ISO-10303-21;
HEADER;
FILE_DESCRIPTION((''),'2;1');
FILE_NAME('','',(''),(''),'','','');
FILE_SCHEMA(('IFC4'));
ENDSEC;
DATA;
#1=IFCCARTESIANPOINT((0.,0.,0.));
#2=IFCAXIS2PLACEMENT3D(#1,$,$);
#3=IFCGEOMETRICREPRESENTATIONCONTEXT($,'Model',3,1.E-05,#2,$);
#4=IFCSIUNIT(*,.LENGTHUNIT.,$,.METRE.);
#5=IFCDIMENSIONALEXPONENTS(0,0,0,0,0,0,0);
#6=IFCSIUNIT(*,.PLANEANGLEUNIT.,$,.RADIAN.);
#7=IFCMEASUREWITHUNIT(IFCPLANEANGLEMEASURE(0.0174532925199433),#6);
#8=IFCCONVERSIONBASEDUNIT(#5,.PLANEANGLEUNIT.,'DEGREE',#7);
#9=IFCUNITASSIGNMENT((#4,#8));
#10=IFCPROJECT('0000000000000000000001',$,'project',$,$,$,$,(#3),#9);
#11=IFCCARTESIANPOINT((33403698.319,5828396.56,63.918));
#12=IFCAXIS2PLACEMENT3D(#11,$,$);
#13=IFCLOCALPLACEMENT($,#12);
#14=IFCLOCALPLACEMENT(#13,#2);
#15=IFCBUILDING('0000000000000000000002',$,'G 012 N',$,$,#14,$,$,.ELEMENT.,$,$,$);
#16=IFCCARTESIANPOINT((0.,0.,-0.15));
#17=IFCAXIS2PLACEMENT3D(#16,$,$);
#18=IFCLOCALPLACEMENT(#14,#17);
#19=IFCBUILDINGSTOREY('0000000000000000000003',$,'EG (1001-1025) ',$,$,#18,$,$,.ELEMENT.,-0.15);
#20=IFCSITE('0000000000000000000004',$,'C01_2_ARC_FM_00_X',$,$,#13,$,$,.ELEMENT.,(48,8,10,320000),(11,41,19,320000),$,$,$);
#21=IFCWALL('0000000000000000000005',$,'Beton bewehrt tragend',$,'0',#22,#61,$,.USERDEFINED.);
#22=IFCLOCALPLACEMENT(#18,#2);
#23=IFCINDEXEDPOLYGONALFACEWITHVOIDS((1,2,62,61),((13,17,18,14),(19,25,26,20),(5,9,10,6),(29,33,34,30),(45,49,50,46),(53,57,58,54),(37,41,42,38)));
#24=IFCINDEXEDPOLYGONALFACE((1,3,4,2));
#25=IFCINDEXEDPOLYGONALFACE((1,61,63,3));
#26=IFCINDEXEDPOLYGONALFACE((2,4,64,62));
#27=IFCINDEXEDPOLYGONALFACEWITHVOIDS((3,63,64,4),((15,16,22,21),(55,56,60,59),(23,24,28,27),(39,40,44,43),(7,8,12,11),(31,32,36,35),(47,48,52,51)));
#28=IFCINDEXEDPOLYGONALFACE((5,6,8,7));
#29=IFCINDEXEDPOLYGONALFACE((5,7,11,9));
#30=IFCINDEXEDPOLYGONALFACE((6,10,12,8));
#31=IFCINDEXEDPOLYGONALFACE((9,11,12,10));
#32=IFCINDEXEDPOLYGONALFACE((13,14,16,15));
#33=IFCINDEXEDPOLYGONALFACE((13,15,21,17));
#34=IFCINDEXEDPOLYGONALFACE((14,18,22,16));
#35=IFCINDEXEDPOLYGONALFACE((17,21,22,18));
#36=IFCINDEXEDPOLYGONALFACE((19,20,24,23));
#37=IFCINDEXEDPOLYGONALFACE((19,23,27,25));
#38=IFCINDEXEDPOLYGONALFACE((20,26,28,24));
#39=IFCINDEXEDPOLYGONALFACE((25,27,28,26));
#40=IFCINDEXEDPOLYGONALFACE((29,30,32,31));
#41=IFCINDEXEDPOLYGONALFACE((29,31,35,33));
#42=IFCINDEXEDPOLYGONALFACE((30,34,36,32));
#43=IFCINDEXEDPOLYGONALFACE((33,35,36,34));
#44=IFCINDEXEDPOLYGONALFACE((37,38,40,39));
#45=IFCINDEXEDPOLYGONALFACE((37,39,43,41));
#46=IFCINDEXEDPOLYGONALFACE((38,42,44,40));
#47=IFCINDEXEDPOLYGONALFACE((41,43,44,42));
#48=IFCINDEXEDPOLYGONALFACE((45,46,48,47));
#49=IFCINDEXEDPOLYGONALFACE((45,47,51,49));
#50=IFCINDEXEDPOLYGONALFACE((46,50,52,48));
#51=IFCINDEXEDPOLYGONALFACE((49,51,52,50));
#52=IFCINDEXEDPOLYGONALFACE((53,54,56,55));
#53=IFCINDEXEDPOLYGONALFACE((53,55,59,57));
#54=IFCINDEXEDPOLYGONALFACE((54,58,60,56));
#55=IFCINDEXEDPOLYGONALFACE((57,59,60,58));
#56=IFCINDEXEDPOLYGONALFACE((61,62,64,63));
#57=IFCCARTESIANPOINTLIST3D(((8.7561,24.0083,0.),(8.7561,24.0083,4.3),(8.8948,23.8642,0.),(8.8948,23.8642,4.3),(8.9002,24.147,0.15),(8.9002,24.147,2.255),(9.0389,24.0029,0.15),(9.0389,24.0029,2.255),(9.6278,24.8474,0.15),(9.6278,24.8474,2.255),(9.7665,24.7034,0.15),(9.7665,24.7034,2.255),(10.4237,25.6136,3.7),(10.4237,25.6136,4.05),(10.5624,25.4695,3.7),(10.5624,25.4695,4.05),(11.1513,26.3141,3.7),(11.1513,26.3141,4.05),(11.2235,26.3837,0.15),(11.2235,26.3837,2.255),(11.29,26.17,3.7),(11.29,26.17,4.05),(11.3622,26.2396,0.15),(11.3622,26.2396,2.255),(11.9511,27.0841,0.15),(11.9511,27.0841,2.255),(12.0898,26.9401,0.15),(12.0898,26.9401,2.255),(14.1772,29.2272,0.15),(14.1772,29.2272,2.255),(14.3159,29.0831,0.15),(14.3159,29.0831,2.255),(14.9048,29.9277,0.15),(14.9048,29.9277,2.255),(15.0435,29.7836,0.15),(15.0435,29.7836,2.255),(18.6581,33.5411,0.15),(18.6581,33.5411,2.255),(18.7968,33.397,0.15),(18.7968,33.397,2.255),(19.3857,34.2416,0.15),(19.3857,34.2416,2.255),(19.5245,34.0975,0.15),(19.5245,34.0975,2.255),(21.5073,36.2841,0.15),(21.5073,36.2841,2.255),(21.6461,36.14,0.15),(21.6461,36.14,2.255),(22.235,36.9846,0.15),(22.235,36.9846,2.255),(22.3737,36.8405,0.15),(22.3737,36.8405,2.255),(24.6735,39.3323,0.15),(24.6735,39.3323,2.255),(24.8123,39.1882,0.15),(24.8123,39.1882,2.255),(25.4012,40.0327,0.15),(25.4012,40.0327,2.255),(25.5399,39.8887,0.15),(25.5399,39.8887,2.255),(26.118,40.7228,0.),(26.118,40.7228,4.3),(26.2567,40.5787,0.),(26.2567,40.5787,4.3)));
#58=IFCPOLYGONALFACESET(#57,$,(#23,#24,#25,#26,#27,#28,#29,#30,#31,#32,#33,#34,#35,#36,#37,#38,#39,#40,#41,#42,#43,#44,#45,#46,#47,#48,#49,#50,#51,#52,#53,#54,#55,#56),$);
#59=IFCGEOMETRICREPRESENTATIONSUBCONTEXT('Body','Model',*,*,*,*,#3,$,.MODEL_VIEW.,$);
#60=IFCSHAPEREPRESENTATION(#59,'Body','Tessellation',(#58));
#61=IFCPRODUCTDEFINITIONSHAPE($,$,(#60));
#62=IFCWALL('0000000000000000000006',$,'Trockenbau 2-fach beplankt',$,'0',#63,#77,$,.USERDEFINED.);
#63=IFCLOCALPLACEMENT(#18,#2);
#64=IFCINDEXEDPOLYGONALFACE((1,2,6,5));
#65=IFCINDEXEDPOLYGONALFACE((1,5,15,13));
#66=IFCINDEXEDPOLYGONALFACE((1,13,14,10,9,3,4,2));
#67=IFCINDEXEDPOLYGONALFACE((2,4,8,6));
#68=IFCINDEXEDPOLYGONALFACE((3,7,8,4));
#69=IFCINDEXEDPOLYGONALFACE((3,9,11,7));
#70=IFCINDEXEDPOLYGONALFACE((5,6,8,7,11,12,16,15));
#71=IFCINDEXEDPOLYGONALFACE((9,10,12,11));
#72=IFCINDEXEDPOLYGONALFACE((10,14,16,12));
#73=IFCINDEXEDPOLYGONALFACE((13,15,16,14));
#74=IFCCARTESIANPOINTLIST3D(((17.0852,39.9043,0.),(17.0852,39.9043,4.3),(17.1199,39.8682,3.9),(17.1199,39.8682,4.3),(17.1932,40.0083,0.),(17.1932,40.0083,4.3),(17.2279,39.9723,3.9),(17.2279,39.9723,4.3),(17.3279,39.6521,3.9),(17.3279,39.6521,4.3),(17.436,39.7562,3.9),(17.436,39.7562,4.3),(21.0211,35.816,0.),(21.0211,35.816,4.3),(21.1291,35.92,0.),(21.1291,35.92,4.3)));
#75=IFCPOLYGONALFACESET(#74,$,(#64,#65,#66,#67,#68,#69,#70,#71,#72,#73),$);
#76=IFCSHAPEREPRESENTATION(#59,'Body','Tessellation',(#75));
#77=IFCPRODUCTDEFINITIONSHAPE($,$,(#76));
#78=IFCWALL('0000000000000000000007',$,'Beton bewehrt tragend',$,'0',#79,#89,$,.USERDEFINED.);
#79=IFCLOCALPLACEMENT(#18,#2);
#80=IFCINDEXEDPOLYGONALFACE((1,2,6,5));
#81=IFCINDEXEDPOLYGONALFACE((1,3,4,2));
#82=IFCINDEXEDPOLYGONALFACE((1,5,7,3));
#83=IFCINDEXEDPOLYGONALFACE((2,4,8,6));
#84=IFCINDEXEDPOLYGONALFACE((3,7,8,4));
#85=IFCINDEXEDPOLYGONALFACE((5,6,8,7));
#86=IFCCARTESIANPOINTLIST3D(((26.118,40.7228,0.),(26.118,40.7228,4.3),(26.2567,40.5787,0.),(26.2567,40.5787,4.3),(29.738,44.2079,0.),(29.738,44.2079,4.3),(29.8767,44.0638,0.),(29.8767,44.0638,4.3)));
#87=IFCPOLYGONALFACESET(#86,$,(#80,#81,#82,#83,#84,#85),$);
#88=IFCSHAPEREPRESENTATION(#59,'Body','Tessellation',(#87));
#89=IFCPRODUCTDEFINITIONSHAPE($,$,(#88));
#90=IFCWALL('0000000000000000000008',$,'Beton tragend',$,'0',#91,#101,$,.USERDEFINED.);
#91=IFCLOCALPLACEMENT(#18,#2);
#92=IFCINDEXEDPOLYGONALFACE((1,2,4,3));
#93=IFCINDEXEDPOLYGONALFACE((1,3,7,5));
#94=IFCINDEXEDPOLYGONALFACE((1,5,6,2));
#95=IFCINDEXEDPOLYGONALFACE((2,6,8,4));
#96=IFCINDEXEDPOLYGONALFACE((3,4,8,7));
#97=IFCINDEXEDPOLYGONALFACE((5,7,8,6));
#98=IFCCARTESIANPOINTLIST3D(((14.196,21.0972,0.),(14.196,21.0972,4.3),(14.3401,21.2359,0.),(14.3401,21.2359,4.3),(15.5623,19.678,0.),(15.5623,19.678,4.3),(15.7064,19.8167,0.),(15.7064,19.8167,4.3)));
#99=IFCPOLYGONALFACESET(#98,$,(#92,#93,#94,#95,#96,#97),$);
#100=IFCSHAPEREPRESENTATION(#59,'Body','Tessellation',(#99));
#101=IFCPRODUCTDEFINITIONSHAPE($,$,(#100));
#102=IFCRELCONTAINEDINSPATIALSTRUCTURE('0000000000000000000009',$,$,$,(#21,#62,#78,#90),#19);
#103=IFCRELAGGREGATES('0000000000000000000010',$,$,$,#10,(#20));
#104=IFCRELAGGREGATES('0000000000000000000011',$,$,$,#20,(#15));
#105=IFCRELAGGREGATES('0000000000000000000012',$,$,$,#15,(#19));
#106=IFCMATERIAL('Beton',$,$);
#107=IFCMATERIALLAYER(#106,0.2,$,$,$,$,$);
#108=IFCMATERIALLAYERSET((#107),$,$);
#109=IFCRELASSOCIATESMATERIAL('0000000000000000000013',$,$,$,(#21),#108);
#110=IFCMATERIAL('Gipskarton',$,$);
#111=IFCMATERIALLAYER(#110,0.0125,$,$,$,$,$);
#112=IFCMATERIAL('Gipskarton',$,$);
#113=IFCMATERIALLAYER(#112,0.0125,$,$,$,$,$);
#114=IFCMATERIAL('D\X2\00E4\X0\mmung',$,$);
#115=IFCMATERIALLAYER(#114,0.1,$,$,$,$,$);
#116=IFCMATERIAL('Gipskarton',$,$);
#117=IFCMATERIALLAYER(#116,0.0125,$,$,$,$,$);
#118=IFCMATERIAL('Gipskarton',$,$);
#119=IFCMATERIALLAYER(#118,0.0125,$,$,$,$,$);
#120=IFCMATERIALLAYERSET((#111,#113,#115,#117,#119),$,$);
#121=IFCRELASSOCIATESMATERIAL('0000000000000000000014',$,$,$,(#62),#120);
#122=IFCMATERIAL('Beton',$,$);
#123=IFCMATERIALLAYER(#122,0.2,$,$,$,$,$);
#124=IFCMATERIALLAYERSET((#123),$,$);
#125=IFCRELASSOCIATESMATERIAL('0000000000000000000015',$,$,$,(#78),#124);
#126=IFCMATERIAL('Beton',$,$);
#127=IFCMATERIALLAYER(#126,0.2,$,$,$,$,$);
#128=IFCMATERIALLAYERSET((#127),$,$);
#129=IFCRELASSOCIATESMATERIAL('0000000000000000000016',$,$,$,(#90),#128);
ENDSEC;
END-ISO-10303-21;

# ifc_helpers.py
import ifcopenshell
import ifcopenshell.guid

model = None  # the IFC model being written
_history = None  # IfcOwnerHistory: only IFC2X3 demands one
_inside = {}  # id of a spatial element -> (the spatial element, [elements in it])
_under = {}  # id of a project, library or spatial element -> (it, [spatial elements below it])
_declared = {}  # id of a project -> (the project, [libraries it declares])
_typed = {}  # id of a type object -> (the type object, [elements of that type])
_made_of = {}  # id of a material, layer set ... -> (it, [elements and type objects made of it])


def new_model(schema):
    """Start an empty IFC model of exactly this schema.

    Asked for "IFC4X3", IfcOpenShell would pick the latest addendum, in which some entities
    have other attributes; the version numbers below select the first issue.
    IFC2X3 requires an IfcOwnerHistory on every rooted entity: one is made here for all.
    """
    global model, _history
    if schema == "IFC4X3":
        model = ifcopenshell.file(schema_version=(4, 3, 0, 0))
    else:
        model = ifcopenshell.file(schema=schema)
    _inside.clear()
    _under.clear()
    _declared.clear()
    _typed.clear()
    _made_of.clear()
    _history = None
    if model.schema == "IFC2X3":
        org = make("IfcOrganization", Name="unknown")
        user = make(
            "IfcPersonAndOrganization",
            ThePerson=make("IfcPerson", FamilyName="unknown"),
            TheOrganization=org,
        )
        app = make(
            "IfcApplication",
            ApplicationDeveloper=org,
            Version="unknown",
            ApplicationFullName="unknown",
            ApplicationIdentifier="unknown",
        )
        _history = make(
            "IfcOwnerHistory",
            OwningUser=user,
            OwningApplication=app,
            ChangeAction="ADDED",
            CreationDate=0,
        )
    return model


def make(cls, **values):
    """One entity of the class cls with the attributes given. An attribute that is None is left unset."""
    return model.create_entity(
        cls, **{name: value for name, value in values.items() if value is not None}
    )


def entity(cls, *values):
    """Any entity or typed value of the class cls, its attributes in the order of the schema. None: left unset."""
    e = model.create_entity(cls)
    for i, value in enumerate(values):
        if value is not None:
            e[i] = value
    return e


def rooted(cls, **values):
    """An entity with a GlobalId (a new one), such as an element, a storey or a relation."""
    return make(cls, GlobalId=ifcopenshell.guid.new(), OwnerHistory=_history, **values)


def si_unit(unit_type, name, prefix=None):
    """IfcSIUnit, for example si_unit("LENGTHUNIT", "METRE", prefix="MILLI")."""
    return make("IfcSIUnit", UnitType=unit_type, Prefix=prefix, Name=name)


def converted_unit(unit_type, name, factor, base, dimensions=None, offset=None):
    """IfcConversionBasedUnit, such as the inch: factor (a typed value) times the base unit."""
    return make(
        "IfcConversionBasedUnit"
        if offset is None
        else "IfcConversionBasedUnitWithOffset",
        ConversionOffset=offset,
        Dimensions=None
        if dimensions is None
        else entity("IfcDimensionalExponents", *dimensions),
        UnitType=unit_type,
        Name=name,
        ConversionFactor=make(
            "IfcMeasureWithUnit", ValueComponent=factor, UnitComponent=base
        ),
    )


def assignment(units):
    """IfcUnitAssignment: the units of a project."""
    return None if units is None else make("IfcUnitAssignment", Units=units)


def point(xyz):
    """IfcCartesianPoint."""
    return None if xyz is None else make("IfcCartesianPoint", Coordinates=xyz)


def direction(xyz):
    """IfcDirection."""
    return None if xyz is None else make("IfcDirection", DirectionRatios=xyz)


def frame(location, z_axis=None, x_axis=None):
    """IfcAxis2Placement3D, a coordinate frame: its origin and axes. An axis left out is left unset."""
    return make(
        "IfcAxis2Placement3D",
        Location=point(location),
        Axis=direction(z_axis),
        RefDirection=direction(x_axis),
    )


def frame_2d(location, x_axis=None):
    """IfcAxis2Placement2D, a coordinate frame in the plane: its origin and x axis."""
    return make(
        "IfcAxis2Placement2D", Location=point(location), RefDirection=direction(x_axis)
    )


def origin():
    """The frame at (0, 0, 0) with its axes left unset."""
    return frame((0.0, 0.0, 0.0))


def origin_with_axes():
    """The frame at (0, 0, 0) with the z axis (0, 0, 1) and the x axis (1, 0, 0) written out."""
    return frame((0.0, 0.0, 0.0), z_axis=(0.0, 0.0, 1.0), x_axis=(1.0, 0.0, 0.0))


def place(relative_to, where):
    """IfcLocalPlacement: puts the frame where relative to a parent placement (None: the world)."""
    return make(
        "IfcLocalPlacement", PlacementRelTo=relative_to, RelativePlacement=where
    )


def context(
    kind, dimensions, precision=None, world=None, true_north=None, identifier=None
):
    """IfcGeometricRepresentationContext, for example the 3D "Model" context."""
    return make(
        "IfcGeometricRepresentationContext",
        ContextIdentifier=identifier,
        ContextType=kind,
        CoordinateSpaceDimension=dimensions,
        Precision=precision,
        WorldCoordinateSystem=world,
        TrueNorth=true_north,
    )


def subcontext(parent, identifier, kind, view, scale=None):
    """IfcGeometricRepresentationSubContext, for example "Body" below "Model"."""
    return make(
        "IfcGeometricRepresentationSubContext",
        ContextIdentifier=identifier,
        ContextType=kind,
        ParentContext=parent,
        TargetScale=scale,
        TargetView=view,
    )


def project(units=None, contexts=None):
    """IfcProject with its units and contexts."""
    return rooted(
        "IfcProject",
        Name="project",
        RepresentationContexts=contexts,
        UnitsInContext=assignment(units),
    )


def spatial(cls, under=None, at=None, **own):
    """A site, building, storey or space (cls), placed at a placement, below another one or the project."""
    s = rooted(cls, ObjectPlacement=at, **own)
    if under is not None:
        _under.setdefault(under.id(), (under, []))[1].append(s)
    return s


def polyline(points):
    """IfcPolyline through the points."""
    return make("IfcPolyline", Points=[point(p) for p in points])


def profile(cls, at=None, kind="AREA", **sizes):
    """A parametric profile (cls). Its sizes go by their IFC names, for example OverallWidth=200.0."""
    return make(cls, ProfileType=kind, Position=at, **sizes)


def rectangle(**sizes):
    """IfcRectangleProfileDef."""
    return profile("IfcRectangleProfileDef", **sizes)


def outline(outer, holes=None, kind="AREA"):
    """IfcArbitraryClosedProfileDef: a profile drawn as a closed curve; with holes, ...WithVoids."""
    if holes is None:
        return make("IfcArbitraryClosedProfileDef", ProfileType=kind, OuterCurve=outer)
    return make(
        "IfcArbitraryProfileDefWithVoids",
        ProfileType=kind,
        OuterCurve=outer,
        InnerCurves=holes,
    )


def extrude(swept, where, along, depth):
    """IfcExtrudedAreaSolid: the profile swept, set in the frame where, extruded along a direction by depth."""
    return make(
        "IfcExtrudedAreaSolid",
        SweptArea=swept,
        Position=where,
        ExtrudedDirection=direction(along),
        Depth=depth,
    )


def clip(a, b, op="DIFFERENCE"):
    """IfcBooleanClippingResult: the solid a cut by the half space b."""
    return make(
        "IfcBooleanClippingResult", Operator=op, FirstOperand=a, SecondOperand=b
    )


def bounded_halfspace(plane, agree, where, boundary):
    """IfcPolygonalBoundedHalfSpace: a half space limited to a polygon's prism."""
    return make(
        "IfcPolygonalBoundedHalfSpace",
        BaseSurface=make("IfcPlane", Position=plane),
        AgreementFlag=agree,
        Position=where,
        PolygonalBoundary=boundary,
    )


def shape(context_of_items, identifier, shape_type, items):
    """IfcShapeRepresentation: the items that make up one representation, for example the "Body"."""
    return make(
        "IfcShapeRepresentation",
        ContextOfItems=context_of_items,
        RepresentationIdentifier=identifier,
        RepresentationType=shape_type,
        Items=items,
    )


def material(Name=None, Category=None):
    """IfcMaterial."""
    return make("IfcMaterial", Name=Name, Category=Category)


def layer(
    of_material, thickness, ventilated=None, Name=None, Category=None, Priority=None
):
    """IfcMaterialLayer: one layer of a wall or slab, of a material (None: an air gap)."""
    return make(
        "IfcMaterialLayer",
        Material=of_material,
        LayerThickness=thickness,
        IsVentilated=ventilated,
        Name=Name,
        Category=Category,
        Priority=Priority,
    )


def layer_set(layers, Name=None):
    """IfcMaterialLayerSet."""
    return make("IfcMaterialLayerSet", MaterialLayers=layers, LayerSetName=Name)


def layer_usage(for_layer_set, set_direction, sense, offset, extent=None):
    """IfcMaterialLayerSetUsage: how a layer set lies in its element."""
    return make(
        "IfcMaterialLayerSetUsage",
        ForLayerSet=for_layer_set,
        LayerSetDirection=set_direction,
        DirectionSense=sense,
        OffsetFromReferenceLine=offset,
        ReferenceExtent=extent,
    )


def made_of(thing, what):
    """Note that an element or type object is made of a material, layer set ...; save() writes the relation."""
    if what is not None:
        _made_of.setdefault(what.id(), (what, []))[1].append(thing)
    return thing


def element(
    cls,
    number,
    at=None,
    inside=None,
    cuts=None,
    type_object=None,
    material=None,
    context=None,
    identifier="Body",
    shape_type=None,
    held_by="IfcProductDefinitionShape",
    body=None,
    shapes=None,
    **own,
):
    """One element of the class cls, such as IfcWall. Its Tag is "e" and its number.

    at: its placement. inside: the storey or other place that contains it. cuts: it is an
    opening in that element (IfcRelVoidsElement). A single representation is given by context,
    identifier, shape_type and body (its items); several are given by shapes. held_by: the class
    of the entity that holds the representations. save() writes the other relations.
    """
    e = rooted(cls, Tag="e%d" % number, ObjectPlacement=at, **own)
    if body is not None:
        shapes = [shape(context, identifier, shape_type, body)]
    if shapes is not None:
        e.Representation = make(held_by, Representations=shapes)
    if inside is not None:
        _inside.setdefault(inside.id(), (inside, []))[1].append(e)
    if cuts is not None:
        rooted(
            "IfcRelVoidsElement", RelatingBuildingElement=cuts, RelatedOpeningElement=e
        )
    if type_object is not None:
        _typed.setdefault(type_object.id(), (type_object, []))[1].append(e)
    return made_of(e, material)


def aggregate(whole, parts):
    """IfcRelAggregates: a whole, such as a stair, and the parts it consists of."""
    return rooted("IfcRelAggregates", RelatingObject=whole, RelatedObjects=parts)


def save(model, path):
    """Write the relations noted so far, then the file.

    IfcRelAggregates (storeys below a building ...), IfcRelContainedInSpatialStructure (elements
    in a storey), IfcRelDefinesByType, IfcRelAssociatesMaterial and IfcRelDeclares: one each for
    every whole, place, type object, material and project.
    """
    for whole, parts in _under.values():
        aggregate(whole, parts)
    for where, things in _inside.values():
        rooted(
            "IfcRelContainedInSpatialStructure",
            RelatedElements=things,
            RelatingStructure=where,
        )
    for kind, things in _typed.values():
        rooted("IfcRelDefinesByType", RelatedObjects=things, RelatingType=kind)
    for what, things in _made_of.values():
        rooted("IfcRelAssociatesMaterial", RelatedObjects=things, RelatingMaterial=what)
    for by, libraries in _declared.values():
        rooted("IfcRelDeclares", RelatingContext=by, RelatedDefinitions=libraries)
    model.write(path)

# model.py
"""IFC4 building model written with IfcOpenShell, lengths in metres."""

from ifc_helpers import new_model, entity, si_unit, converted_unit, frame, frame_2d, origin, origin_with_axes, place, context, subcontext, project, spatial, polyline, rectangle, outline, extrude, clip, bounded_halfspace, material, layer, layer_set, layer_usage, element, save


model = new_model("IFC4")

# Units and contexts
model_context = context("Model", 3, precision=1e-05, world=origin())
body_context = subcontext(model_context, "Body", "Model", "MODEL_VIEW")
ifc_project = project(units=[si_unit("LENGTHUNIT", "METRE"), converted_unit("PLANEANGLEUNIT", "DEGREE", entity("IfcPlaneAngleMeasure", 0.0174532925199433), si_unit("PLANEANGLEUNIT", "RADIAN"), dimensions=[0, 0, 0, 0, 0, 0, 0])], contexts=[model_context])

# Site, building, storey
site_placement = place(None, frame((33403698.319, 5828396.56, 63.918)))
site = spatial("IfcSite", under=ifc_project, at=site_placement, Name="C01_2_ARC_FM_00_X", CompositionType="ELEMENT", RefLatitude=(48, 8, 10, 320000), RefLongitude=(11, 41, 19, 320000))
building_placement = place(site_placement, origin())
building = spatial("IfcBuilding", under=site, at=building_placement, Name="G 012 N", CompositionType="ELEMENT")
storey_placement = place(building_placement, frame((0.0, 0.0, -0.15)))
storey = spatial("IfcBuildingStorey", under=building, at=storey_placement, Name="EG (1001-1025) ", CompositionType="ELEMENT", Elevation=-0.15)

# Wall, openings
ifc_material_1 = material(Name="Beton")
ifc_layer_1 = layer(ifc_material_1, 0.2)
ifc_layer_set_1 = layer_set([ifc_layer_1])
ifc_layer_usage_1 = layer_usage(ifc_layer_set_1, "AXIS2", "POSITIVE", 0.0)
wall_1_placement = place(storey_placement, frame((26.118, 40.7228, 0.0), z_axis=(0.0, 0.0, 1.0), x_axis=(-0.720408, -0.693551, 0.0)))
wall_1 = element("IfcWall", 1, at=wall_1_placement, inside=storey, material=ifc_layer_usage_1, Name="Beton bewehrt tragend", ObjectType="0", PredefinedType="USERDEFINED", context=body_context, shape_type="SweptSolid", body=[
    extrude(rectangle(XDim=24.1, YDim=0.2, at=frame_2d((12.05, 0.1), x_axis=(1.0, 0.0))), origin_with_axes(), (0.0, 0.0, 1.0), 4.3),
])
opening_1_placement = place(wall_1_placement, frame((15.565, 0.0, 0.15), z_axis=(0.0, 1.0, 0.0), x_axis=(0.0, 0.0, 1.0)))
element("IfcOpeningElement", 2, at=opening_1_placement, cuts=wall_1, ObjectType="Opening", context=body_context, shape_type="SweptSolid", body=[
    extrude(outline(polyline([(0.0, 1.01), (2.105, 1.01), (2.105, 0.0), (0.0, 0.0), (0.0, 1.01)])), origin_with_axes(), (0.0, 0.0, 1.0), 0.2),
])
opening_2_placement = place(wall_1_placement, frame((0.995, 0.0, 0.15), z_axis=(0.0, 1.0, 0.0), x_axis=(0.0, 0.0, 1.0)))
element("IfcOpeningElement", 3, at=opening_2_placement, cuts=wall_1, ObjectType="Opening", context=body_context, shape_type="SweptSolid", body=[
    extrude(outline(polyline([(0.0, 1.01), (2.105, 1.01), (2.105, 0.0), (0.0, 0.0), (0.0, 1.01)])), origin_with_axes(), (0.0, 0.0, 1.0), 0.2),
])
opening_3_placement = place(wall_1_placement, frame((5.39, 0.0, 0.15), z_axis=(0.0, 1.0, 0.0), x_axis=(0.0, 0.0, 1.0)))
element("IfcOpeningElement", 4, at=opening_3_placement, cuts=wall_1, ObjectType="Opening", context=body_context, shape_type="SweptSolid", body=[
    extrude(outline(polyline([(0.0, 1.01), (2.105, 1.01), (2.105, 0.0), (0.0, 0.0), (0.0, 1.01)])), origin_with_axes(), (0.0, 0.0, 1.0), 0.2),
])
opening_4_placement = place(wall_1_placement, frame((9.345, 0.0, 0.15), z_axis=(0.0, 1.0, 0.0), x_axis=(0.0, 0.0, 1.0)))
element("IfcOpeningElement", 5, at=opening_4_placement, cuts=wall_1, ObjectType="Opening", context=body_context, shape_type="SweptSolid", body=[
    extrude(outline(polyline([(0.0, 1.01), (2.105, 1.01), (2.105, 0.0), (0.0, 0.0), (0.0, 1.01)])), origin_with_axes(), (0.0, 0.0, 1.0), 0.2),
])
opening_5_placement = place(wall_1_placement, frame((23.9, 0.2, 0.15), z_axis=(0.0, -1.0, 0.0), x_axis=(0.0, 0.0, 1.0)))
element("IfcOpeningElement", 6, at=opening_5_placement, cuts=wall_1, ObjectType="Opening", context=body_context, shape_type="SweptSolid", body=[
    extrude(outline(polyline([(0.0, 1.01), (2.105, 1.01), (2.105, 0.0), (0.0, 0.0), (0.0, 1.01)])), origin_with_axes(), (0.0, 0.0, 1.0), 0.2),
])
opening_6_placement = place(wall_1_placement, frame((19.665, 0.0, 0.15), z_axis=(0.0, 1.0, 0.0), x_axis=(0.0, 0.0, 1.0)))
element("IfcOpeningElement", 7, at=opening_6_placement, cuts=wall_1, ObjectType="Opening", context=body_context, shape_type="SweptSolid", body=[
    extrude(outline(polyline([(0.0, 1.01), (2.105, 1.01), (2.105, 0.0), (0.0, 0.0), (0.0, 1.01)])), origin_with_axes(), (0.0, 0.0, 1.0), 0.2),
])
opening_7_placement = place(wall_1_placement, frame((21.7853, 0.2, 3.7), z_axis=(0.0, -1.0, 0.0), x_axis=(0.0, 0.0, 1.0)))
element("IfcOpeningElement", 8, at=opening_7_placement, cuts=wall_1, ObjectType="Opening", context=body_context, shape_type="SweptSolid", body=[
    extrude(outline(polyline([(0.0, 1.01), (0.35, 1.01), (0.35, 0.0), (0.0, 0.0), (0.0, 1.01)])), origin_with_axes(), (0.0, 0.0, 1.0), 0.2),
])

# Walls
ifc_material_2 = material(Name="Gipskarton")
ifc_layer_2 = layer(ifc_material_2, 0.0125)
ifc_material_3 = material(Name="Gipskarton")
ifc_layer_3 = layer(ifc_material_3, 0.0125)
ifc_material_4 = material(Name="Dämmung")
ifc_layer_4 = layer(ifc_material_4, 0.1)
ifc_material_5 = material(Name="Gipskarton")
ifc_layer_5 = layer(ifc_material_5, 0.0125)
ifc_material_6 = material(Name="Gipskarton")
ifc_layer_6 = layer(ifc_material_6, 0.0125)
ifc_layer_set_2 = layer_set([ifc_layer_2, ifc_layer_3, ifc_layer_4, ifc_layer_5, ifc_layer_6])
ifc_layer_usage_2 = layer_usage(ifc_layer_set_2, "AXIS2", "POSITIVE", 0.0)
wall_2_placement = place(storey_placement, frame((17.0852, 39.9043, 0.0), z_axis=(0.0, 0.0, 1.0), x_axis=(0.693551, -0.720408, 0.0)))
element("IfcWall", 9, at=wall_2_placement, inside=storey, material=ifc_layer_usage_2, Name="Trockenbau 2-fach beplankt", ObjectType="0", PredefinedType="USERDEFINED", context=body_context, shape_type="Clipping", body=[
    clip(extrude(rectangle(XDim=5.675, YDim=0.15, at=frame_2d((2.8375, 0.075), x_axis=(1.0, 0.0))), origin_with_axes(), (0.0, 0.0, 1.0), 4.3), bounded_halfspace(frame((0.2, 0.075, 3.9), z_axis=(0.0, 0.0, -1.0), x_axis=(0.0, -1.0, 0.0)), True, origin_with_axes(), polyline([(0.05, 0.15), (0.05, 0.0), (0.35, 0.0), (0.35, 0.15), (0.05, 0.15)]))),
])
ifc_material_7 = material(Name="Beton")
ifc_layer_7 = layer(ifc_material_7, 0.2)
ifc_layer_set_3 = layer_set([ifc_layer_7])
ifc_layer_usage_3 = layer_usage(ifc_layer_set_3, "AXIS2", "POSITIVE", 0.0)
wall_3_placement = place(storey_placement, frame((26.2567, 40.5787, 0.0), z_axis=(0.0, 0.0, 1.0), x_axis=(0.720408, 0.693551, 0.0)))
element("IfcWall", 10, at=wall_3_placement, inside=storey, material=ifc_layer_usage_3, Name="Beton bewehrt tragend", ObjectType="0", PredefinedType="USERDEFINED", context=body_context, shape_type="SweptSolid", body=[
    extrude(rectangle(XDim=5.025, YDim=0.2, at=frame_2d((2.5125, 0.1), x_axis=(1.0, 0.0))), origin_with_axes(), (0.0, 0.0, 1.0), 4.3),
])
ifc_material_8 = material(Name="Beton")
ifc_layer_8 = layer(ifc_material_8, 0.2)
ifc_layer_set_4 = layer_set([ifc_layer_8])
ifc_layer_usage_4 = layer_usage(ifc_layer_set_4, "AXIS2", "POSITIVE", 0.0)
wall_4_placement = place(storey_placement, frame((15.7064, 19.8167, 0.0), z_axis=(0.0, 0.0, 1.0), x_axis=(-0.693551, 0.720408, 0.0)))
element("IfcWall", 11, at=wall_4_placement, inside=storey, material=ifc_layer_usage_4, Name="Beton tragend", ObjectType="0", PredefinedType="USERDEFINED", context=body_context, shape_type="SweptSolid", body=[
    extrude(rectangle(XDim=1.97, YDim=0.2, at=frame_2d((0.985, 0.1), x_axis=(1.0, 0.0))), origin_with_axes(), (0.0, 0.0, 1.0), 4.3),
])

save(model, "model.ifc")
